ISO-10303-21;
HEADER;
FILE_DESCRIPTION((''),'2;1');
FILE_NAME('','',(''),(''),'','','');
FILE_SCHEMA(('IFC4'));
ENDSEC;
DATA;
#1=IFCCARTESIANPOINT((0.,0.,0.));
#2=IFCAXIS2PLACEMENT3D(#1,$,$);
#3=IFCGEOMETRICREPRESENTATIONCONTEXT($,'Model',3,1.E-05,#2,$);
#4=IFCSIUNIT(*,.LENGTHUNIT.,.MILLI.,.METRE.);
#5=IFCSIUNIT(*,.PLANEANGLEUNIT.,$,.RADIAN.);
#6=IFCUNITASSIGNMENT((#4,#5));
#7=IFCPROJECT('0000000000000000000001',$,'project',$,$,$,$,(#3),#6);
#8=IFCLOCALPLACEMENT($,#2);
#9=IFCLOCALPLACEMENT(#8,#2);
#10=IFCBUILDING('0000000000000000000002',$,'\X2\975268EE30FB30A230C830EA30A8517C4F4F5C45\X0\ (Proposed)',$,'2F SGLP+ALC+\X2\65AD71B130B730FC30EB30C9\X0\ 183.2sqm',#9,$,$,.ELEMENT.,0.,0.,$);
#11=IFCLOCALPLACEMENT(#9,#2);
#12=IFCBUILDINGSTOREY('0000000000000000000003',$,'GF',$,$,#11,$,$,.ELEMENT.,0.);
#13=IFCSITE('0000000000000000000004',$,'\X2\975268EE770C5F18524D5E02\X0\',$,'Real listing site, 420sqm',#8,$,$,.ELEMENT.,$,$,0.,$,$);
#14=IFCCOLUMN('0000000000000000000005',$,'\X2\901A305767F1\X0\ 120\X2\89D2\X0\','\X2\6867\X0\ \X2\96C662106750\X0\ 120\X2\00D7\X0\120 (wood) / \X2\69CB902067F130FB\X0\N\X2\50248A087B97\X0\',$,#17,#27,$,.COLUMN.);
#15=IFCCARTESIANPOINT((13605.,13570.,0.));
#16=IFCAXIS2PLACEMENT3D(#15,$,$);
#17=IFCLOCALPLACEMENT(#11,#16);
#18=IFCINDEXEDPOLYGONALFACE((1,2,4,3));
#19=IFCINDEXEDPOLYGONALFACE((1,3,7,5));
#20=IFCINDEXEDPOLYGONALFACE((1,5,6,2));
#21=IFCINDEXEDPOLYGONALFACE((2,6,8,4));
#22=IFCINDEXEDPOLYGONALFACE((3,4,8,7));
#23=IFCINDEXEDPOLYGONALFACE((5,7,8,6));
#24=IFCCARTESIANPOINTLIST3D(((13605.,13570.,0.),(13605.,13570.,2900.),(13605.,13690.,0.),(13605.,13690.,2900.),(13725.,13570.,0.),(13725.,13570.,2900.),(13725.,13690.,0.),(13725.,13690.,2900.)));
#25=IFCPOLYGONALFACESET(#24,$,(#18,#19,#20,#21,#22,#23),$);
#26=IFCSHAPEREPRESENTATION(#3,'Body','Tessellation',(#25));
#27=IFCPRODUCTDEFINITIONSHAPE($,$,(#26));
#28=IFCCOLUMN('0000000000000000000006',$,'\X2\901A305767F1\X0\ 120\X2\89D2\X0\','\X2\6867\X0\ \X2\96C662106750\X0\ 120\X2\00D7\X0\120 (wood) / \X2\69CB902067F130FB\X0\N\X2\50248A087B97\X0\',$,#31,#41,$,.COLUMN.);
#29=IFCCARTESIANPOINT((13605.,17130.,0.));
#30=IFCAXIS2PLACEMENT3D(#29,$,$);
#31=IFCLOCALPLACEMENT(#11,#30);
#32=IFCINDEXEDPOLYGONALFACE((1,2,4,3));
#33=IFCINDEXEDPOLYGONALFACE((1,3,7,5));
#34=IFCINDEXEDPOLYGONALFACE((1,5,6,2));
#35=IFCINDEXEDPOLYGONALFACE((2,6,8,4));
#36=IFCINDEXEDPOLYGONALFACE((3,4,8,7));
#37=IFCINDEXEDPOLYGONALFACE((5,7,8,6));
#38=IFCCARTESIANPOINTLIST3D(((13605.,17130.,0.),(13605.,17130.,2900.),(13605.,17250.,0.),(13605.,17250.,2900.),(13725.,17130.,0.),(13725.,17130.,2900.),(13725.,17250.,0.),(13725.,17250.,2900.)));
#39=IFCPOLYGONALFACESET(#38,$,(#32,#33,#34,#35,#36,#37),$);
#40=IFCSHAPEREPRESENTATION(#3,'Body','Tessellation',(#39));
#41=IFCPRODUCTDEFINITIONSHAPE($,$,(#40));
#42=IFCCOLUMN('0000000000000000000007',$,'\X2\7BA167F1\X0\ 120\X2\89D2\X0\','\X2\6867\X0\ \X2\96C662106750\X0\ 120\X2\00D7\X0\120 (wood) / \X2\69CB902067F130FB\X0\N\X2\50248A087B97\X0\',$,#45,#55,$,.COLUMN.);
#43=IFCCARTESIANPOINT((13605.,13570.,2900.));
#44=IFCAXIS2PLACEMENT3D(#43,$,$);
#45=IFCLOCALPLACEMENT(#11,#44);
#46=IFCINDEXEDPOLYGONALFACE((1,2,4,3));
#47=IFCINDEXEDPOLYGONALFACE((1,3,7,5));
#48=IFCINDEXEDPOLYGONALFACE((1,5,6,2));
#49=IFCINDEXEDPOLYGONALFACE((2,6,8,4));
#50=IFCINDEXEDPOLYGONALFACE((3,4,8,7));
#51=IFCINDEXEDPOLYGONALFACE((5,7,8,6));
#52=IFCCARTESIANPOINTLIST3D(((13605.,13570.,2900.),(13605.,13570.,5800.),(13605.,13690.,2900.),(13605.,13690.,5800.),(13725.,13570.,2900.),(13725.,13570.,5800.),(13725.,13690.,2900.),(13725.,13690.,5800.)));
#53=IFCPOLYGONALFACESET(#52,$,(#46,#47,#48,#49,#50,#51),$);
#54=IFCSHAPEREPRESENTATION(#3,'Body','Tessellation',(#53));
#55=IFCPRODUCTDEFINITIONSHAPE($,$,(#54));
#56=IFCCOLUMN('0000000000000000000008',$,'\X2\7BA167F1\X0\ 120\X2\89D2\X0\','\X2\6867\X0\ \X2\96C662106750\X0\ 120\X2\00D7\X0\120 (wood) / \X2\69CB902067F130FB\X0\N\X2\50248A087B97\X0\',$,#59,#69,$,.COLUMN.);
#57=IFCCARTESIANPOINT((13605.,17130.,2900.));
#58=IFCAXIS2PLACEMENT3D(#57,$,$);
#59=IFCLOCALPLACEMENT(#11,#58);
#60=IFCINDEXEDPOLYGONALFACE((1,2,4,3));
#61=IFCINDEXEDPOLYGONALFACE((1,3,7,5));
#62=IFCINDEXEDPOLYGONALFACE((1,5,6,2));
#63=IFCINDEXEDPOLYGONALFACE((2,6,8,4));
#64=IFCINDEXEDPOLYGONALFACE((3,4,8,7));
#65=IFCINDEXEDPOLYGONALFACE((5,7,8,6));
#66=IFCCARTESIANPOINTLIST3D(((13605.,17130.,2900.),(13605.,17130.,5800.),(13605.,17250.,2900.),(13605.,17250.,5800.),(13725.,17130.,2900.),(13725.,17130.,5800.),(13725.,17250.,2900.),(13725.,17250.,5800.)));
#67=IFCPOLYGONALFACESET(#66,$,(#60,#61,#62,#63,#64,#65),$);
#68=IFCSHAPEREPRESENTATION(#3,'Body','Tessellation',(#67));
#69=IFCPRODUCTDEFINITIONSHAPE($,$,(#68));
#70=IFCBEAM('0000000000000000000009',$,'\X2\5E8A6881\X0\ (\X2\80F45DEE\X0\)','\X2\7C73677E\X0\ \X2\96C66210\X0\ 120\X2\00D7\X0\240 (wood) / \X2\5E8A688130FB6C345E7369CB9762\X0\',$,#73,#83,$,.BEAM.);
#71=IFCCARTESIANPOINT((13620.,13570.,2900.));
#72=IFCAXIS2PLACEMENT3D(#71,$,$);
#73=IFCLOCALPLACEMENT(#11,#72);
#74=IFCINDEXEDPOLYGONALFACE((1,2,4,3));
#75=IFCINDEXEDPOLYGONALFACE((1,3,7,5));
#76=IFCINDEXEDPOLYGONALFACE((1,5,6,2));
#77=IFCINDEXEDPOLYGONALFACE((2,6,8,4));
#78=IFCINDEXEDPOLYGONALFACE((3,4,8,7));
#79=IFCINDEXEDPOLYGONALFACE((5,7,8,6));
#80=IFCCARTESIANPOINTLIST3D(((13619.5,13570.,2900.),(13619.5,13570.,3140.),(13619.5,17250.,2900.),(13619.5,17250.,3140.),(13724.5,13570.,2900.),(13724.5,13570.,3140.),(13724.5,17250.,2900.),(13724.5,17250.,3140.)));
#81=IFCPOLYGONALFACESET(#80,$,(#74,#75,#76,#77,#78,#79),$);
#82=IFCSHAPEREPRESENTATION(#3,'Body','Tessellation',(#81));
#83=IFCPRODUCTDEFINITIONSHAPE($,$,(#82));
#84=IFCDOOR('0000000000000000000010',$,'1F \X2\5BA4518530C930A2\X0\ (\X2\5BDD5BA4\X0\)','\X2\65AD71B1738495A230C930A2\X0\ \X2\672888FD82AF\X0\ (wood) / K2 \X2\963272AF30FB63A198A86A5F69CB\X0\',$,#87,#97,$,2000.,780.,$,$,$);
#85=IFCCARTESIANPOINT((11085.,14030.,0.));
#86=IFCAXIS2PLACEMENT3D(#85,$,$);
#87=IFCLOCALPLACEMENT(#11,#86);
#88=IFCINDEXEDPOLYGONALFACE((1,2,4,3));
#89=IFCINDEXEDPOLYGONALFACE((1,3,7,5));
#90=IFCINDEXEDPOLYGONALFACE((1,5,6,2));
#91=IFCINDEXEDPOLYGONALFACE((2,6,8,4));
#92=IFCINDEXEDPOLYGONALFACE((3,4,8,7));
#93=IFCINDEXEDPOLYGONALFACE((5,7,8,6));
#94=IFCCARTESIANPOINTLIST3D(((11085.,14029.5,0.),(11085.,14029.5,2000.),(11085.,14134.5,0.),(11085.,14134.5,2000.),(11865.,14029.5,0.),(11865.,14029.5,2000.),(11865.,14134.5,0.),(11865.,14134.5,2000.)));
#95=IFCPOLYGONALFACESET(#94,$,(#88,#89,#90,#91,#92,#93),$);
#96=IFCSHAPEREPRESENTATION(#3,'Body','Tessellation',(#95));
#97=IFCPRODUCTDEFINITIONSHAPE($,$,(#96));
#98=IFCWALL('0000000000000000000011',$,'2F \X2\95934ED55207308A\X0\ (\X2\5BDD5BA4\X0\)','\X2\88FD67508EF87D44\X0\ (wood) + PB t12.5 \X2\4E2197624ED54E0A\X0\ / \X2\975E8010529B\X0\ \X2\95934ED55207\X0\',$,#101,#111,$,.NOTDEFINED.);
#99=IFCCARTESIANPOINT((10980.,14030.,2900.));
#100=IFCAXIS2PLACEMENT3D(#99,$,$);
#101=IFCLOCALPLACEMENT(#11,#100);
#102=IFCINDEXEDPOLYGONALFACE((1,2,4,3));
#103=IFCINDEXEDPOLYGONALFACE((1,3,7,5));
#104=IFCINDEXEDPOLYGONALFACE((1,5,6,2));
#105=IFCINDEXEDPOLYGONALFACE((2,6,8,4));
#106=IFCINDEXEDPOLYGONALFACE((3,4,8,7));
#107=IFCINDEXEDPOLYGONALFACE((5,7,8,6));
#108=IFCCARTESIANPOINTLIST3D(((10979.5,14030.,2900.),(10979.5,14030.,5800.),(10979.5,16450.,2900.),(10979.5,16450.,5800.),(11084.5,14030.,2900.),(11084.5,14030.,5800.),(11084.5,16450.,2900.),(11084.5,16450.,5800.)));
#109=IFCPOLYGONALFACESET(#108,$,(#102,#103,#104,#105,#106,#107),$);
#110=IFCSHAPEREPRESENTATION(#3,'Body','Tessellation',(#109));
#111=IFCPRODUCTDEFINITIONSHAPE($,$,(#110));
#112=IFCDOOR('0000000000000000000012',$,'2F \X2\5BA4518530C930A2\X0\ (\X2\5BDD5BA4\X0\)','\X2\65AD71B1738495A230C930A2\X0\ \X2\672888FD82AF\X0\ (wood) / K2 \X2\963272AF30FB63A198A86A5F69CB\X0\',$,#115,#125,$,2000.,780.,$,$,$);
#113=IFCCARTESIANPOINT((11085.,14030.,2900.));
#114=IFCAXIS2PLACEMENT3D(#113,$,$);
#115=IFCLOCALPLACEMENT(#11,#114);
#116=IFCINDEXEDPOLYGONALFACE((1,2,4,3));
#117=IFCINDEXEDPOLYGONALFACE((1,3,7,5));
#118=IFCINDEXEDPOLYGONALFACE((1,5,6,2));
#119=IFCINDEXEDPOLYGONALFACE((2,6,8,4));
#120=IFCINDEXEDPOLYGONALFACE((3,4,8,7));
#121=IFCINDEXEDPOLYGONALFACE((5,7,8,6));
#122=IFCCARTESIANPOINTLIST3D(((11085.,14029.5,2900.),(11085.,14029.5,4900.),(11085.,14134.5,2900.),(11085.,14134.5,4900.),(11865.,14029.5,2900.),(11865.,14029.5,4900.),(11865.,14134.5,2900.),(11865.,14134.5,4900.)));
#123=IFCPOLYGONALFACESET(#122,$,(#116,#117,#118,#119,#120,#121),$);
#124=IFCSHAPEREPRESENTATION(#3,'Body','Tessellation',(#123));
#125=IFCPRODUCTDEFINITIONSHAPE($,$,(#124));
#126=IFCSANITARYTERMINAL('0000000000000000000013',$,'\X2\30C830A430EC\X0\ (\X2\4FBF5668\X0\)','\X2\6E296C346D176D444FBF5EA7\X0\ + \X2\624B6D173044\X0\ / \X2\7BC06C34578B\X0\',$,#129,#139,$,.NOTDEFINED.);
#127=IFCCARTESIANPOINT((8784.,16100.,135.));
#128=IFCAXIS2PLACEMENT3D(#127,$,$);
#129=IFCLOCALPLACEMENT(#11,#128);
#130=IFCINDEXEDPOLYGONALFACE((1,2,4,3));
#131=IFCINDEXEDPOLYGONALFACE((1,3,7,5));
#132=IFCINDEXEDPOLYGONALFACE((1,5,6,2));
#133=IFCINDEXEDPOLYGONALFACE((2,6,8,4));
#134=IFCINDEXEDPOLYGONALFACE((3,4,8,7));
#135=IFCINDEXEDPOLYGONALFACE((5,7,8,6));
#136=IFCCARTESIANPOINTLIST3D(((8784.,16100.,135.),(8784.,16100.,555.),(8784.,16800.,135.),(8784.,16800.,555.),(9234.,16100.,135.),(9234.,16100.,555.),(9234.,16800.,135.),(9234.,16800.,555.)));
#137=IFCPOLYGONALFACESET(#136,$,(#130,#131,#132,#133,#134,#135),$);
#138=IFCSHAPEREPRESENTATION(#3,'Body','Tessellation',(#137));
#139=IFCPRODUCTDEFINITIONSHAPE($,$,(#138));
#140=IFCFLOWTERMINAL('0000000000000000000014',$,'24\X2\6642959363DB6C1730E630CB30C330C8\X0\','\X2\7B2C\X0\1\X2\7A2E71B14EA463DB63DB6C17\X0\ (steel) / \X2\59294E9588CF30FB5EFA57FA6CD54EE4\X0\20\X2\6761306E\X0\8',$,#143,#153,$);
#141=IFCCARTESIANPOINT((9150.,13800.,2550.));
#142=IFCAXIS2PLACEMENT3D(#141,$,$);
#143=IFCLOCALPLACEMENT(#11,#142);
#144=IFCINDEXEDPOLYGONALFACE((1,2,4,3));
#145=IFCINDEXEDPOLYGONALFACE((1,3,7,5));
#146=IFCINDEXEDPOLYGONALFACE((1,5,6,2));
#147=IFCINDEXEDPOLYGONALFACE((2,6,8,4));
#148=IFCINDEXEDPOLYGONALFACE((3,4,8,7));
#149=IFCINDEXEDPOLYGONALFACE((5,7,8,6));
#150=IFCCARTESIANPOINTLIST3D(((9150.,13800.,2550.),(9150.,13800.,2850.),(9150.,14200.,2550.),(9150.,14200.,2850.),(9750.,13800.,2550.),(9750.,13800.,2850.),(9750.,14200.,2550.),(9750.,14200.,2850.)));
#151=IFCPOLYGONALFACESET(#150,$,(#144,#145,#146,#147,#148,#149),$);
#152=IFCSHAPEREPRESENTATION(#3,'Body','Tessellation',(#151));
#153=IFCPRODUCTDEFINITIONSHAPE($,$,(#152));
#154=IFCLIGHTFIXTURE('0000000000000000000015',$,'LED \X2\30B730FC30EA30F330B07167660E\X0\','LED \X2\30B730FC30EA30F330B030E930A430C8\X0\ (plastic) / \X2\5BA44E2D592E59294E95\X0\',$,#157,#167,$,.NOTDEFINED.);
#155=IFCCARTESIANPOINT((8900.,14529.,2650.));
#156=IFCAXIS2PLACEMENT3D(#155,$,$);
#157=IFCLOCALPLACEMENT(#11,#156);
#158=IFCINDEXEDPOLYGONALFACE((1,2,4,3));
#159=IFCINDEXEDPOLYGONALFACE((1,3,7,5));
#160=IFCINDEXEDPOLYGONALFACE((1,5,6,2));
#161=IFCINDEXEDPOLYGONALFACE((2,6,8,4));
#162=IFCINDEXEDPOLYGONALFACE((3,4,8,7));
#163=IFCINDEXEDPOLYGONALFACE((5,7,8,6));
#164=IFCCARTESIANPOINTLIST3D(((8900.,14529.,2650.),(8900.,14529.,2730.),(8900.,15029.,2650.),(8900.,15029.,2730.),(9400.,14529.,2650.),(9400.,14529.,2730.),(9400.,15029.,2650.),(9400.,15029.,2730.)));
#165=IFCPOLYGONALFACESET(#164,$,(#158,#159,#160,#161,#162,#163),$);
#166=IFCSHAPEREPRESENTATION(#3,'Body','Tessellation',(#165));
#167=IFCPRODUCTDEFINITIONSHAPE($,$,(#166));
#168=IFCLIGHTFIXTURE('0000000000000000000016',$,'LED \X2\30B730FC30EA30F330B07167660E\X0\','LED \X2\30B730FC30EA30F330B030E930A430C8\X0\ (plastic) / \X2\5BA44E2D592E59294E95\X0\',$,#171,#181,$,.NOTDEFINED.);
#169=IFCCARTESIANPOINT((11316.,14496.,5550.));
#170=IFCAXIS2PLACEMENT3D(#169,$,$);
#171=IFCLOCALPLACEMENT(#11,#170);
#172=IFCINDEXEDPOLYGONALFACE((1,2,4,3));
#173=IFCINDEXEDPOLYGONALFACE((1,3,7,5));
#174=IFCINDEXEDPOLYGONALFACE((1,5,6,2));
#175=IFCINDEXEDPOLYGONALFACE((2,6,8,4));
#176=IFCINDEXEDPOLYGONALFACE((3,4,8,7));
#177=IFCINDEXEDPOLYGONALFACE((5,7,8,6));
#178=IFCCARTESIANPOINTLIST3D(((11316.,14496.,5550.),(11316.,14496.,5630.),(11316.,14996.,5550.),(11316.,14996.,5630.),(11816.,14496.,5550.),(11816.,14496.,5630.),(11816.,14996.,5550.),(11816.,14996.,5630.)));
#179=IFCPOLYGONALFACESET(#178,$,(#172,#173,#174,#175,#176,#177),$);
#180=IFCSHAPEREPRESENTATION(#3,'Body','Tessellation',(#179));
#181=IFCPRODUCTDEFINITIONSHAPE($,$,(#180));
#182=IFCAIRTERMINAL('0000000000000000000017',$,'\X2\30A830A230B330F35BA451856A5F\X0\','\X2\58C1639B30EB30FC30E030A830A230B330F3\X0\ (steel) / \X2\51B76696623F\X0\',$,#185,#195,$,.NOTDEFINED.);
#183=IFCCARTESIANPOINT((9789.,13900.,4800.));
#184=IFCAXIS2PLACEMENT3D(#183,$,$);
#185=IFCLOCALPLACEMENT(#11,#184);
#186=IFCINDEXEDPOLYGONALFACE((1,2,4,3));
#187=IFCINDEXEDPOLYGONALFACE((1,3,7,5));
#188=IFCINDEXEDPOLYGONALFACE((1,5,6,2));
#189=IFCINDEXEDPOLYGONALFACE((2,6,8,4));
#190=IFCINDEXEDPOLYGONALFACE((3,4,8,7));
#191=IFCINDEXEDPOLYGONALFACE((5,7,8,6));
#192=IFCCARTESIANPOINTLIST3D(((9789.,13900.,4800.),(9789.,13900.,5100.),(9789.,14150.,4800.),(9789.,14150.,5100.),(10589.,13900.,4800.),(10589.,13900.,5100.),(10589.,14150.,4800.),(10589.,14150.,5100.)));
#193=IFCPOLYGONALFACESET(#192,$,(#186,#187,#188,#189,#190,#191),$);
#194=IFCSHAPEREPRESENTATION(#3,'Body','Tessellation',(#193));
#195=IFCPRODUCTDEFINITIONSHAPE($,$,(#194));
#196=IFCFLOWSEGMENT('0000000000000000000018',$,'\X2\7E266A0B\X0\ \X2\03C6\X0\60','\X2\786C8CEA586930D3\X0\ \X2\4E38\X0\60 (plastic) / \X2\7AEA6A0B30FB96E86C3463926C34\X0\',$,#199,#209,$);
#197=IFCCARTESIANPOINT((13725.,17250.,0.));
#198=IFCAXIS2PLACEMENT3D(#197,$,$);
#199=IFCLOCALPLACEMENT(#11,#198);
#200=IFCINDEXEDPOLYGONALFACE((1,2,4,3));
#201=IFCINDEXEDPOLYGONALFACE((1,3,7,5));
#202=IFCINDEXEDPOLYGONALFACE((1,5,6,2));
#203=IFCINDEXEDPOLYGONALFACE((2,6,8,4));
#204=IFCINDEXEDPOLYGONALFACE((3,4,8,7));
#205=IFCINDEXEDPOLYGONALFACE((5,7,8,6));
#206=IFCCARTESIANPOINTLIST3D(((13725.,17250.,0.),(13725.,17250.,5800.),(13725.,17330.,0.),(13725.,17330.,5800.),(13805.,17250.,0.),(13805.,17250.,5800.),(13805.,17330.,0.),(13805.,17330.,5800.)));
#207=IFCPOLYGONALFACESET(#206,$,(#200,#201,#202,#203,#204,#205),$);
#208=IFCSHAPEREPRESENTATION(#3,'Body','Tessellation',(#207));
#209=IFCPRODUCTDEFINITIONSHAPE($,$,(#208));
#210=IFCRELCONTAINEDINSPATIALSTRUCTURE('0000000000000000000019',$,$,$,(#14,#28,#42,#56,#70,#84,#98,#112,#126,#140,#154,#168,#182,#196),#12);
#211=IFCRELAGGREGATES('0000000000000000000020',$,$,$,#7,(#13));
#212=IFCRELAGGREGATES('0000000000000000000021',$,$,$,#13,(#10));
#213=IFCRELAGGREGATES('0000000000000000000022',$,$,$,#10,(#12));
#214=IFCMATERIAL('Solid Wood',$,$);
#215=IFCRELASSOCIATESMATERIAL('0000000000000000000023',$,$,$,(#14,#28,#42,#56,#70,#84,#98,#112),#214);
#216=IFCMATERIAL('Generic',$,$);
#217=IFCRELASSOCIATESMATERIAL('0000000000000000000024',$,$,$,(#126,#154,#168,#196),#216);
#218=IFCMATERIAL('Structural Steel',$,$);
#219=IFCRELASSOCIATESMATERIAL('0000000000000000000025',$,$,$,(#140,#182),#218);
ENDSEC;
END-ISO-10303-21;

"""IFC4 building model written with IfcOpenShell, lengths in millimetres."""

from ifc_helpers import new_model, si_unit, frame, frame_2d, origin, place, context, project, spatial, rectangle, extrude, material, element, save


model = new_model("IFC4")

# Units and contexts
model_context = context("Model", 3, precision=1e-05, world=origin())
ifc_project = project(units=[si_unit("LENGTHUNIT", "METRE", prefix="MILLI"), si_unit("PLANEANGLEUNIT", "RADIAN")], contexts=[model_context])

# Site, building, storey
site_placement = place(None, origin())
site = spatial("IfcSite", under=ifc_project, at=site_placement, Name="青森県弘前市", ObjectType="Real listing site, 420sqm", CompositionType="ELEMENT", RefElevation=0.0)
building_placement = place(site_placement, origin())
building = spatial("IfcBuilding", under=site, at=building_placement, Name="青森・アトリエ兼住居 (Proposed)", ObjectType="2F SGLP+ALC+断熱シールド 183.2sqm", CompositionType="ELEMENT", ElevationOfRefHeight=0.0, ElevationOfTerrain=0.0)
storey_placement = place(building_placement, origin())
storey = spatial("IfcBuildingStorey", under=building, at=storey_placement, Name="GF", CompositionType="ELEMENT", Elevation=0.0)

# Columns
ifc_material_1 = material(Name="Solid Wood")
column_1_placement = place(storey_placement, frame((13605.0, 13570.0, 0.0)))
element("IfcColumn", 1, at=column_1_placement, inside=storey, material=ifc_material_1, Name="通し柱 120角", Description="桧 集成材 120×120 (wood) / 構造柱・N値計算", PredefinedType="COLUMN", context=model_context, shape_type="SweptSolid", body=[
    extrude(rectangle(XDim=120.0, YDim=120.0, at=frame_2d((60.0, 60.0))), frame((13605.0, 13570.0, 0.0)), (0.0, 0.0, 1.0), 2900.0),
])
column_2_placement = place(storey_placement, frame((13605.0, 17130.0, 0.0)))
element("IfcColumn", 2, at=column_2_placement, inside=storey, material=ifc_material_1, Name="通し柱 120角", Description="桧 集成材 120×120 (wood) / 構造柱・N値計算", PredefinedType="COLUMN", context=model_context, shape_type="SweptSolid", body=[
    extrude(rectangle(XDim=120.0, YDim=120.0, at=frame_2d((60.0, 60.0))), frame((13605.0, 17130.0, 0.0)), (0.0, 0.0, 1.0), 2900.0),
])
column_3_placement = place(storey_placement, frame((13605.0, 13570.0, 2900.0)))
element("IfcColumn", 3, at=column_3_placement, inside=storey, material=ifc_material_1, Name="管柱 120角", Description="桧 集成材 120×120 (wood) / 構造柱・N値計算", PredefinedType="COLUMN", context=model_context, shape_type="SweptSolid", body=[
    extrude(rectangle(XDim=120.0, YDim=120.0, at=frame_2d((60.0, 60.0))), frame((13605.0, 13570.0, 2900.0)), (0.0, 0.0, 1.0), 2900.0),
])
column_4_placement = place(storey_placement, frame((13605.0, 17130.0, 2900.0)))
element("IfcColumn", 4, at=column_4_placement, inside=storey, material=ifc_material_1, Name="管柱 120角", Description="桧 集成材 120×120 (wood) / 構造柱・N値計算", PredefinedType="COLUMN", context=model_context, shape_type="SweptSolid", body=[
    extrude(rectangle(XDim=120.0, YDim=120.0, at=frame_2d((60.0, 60.0))), frame((13605.0, 17130.0, 2900.0)), (0.0, 0.0, 1.0), 2900.0),
])

# Beam
beam_1_placement = place(storey_placement, frame((13620.0, 13570.0, 2900.0)))
element("IfcBeam", 5, at=beam_1_placement, inside=storey, material=ifc_material_1, Name="床梁 (胴差)", Description="米松 集成 120×240 (wood) / 床梁・水平構面", PredefinedType="BEAM", context=model_context, shape_type="SweptSolid", body=[
    extrude(rectangle(XDim=105.0, YDim=3680.0, at=frame_2d((52.0, 1840.0))), frame((13620.0, 13570.0, 2900.0)), (0.0, 0.0, 1.0), 240.0),
])

# Door
door_1_placement = place(storey_placement, frame((11085.0, 14030.0, 0.0)))
element("IfcDoor", 6, at=door_1_placement, inside=storey, material=ifc_material_1, Name="1F 室内ドア (寝室)", Description="断熱玄関ドア 木製芯 (wood) / K2 防犯・採風機構", OverallHeight=2000.0, OverallWidth=780.0, context=model_context, shape_type="SweptSolid", body=[
    extrude(rectangle(XDim=780.0, YDim=105.0, at=frame_2d((390.0, 52.0))), frame((11085.0, 14030.0, 0.0)), (0.0, 0.0, 1.0), 2000.0),
])

# Wall
wall_1_placement = place(storey_placement, frame((10980.0, 14030.0, 2900.0)))
element("IfcWall", 7, at=wall_1_placement, inside=storey, material=ifc_material_1, Name="2F 間仕切り (寝室)", Description="製材軸組 (wood) + PB t12.5 両面仕上 / 非耐力 間仕切", PredefinedType="NOTDEFINED", context=model_context, shape_type="SweptSolid", body=[
    extrude(rectangle(XDim=105.0, YDim=2420.0, at=frame_2d((52.0, 1210.0))), frame((10980.0, 14030.0, 2900.0)), (0.0, 0.0, 1.0), 2900.0),
])

# Door
door_2_placement = place(storey_placement, frame((11085.0, 14030.0, 2900.0)))
element("IfcDoor", 8, at=door_2_placement, inside=storey, material=ifc_material_1, Name="2F 室内ドア (寝室)", Description="断熱玄関ドア 木製芯 (wood) / K2 防犯・採風機構", OverallHeight=2000.0, OverallWidth=780.0, context=model_context, shape_type="SweptSolid", body=[
    extrude(rectangle(XDim=780.0, YDim=105.0, at=frame_2d((390.0, 52.0))), frame((11085.0, 14030.0, 2900.0)), (0.0, 0.0, 1.0), 2000.0),
])

# Sanitary terminal
ifc_material_2 = material(Name="Generic")
sanitary_terminal_placement = place(storey_placement, frame((8784.0, 16100.0, 135.0)))
element("IfcSanitaryTerminal", 9, at=sanitary_terminal_placement, inside=storey, material=ifc_material_2, Name="トイレ (便器)", Description="温水洗浄便座 + 手洗い / 節水型", PredefinedType="NOTDEFINED", context=model_context, shape_type="SweptSolid", body=[
    extrude(rectangle(XDim=450.0, YDim=700.0, at=frame_2d((225.0, 350.0))), frame((8784.0, 16100.0, 135.0)), (0.0, 0.0, 1.0), 420.0),
])

# Flow terminal
ifc_material_3 = material(Name="Structural Steel")
flow_terminal_placement = place(storey_placement, frame((9150.0, 13800.0, 2550.0)))
element("IfcFlowTerminal", 10, at=flow_terminal_placement, inside=storey, material=ifc_material_3, Name="24時間換気ユニット", Description="第1種熱交換換気 (steel) / 天井裏・建基法令20条の8", context=model_context, shape_type="SweptSolid", body=[
    extrude(rectangle(XDim=600.0, YDim=400.0, at=frame_2d((300.0, 200.0))), frame((9150.0, 13800.0, 2550.0)), (0.0, 0.0, 1.0), 300.0),
])

# Light fixtures
light_fixture_1_placement = place(storey_placement, frame((8900.0, 14529.0, 2650.0)))
element("IfcLightFixture", 11, at=light_fixture_1_placement, inside=storey, material=ifc_material_2, Name="LED シーリング照明", Description="LED シーリングライト (plastic) / 室中央天井", PredefinedType="NOTDEFINED", context=model_context, shape_type="SweptSolid", body=[
    extrude(rectangle(XDim=500.0, YDim=500.0, at=frame_2d((250.0, 250.0))), frame((8900.0, 14529.0, 2650.0)), (0.0, 0.0, 1.0), 80.0),
])
light_fixture_2_placement = place(storey_placement, frame((11316.0, 14496.0, 5550.0)))
element("IfcLightFixture", 12, at=light_fixture_2_placement, inside=storey, material=ifc_material_2, Name="LED シーリング照明", Description="LED シーリングライト (plastic) / 室中央天井", PredefinedType="NOTDEFINED", context=model_context, shape_type="SweptSolid", body=[
    extrude(rectangle(XDim=500.0, YDim=500.0, at=frame_2d((250.0, 250.0))), frame((11316.0, 14496.0, 5550.0)), (0.0, 0.0, 1.0), 80.0),
])

# Air terminal
air_terminal_placement = place(storey_placement, frame((9789.0, 13900.0, 4800.0)))
element("IfcAirTerminal", 13, at=air_terminal_placement, inside=storey, material=ifc_material_3, Name="エアコン室内機", Description="壁掛ルームエアコン (steel) / 冷暖房", PredefinedType="NOTDEFINED", context=model_context, shape_type="SweptSolid", body=[
    extrude(rectangle(XDim=800.0, YDim=250.0, at=frame_2d((400.0, 125.0))), frame((9789.0, 13900.0, 4800.0)), (0.0, 0.0, 1.0), 300.0),
])

# Flow segment
flow_segment_placement = place(storey_placement, frame((13725.0, 17250.0, 0.0)))
element("IfcFlowSegment", 14, at=flow_segment_placement, inside=storey, material=ifc_material_2, Name="縦樋 φ60", Description="硬質塩ビ 丸60 (plastic) / 竪樋・雨水排水", context=model_context, shape_type="SweptSolid", body=[
    extrude(rectangle(XDim=80.0, YDim=80.0, at=frame_2d((40.0, 40.0))), frame((13725.0, 17250.0, 0.0)), (0.0, 0.0, 1.0), 5800.0),
])

save(model, "model.ifc")
